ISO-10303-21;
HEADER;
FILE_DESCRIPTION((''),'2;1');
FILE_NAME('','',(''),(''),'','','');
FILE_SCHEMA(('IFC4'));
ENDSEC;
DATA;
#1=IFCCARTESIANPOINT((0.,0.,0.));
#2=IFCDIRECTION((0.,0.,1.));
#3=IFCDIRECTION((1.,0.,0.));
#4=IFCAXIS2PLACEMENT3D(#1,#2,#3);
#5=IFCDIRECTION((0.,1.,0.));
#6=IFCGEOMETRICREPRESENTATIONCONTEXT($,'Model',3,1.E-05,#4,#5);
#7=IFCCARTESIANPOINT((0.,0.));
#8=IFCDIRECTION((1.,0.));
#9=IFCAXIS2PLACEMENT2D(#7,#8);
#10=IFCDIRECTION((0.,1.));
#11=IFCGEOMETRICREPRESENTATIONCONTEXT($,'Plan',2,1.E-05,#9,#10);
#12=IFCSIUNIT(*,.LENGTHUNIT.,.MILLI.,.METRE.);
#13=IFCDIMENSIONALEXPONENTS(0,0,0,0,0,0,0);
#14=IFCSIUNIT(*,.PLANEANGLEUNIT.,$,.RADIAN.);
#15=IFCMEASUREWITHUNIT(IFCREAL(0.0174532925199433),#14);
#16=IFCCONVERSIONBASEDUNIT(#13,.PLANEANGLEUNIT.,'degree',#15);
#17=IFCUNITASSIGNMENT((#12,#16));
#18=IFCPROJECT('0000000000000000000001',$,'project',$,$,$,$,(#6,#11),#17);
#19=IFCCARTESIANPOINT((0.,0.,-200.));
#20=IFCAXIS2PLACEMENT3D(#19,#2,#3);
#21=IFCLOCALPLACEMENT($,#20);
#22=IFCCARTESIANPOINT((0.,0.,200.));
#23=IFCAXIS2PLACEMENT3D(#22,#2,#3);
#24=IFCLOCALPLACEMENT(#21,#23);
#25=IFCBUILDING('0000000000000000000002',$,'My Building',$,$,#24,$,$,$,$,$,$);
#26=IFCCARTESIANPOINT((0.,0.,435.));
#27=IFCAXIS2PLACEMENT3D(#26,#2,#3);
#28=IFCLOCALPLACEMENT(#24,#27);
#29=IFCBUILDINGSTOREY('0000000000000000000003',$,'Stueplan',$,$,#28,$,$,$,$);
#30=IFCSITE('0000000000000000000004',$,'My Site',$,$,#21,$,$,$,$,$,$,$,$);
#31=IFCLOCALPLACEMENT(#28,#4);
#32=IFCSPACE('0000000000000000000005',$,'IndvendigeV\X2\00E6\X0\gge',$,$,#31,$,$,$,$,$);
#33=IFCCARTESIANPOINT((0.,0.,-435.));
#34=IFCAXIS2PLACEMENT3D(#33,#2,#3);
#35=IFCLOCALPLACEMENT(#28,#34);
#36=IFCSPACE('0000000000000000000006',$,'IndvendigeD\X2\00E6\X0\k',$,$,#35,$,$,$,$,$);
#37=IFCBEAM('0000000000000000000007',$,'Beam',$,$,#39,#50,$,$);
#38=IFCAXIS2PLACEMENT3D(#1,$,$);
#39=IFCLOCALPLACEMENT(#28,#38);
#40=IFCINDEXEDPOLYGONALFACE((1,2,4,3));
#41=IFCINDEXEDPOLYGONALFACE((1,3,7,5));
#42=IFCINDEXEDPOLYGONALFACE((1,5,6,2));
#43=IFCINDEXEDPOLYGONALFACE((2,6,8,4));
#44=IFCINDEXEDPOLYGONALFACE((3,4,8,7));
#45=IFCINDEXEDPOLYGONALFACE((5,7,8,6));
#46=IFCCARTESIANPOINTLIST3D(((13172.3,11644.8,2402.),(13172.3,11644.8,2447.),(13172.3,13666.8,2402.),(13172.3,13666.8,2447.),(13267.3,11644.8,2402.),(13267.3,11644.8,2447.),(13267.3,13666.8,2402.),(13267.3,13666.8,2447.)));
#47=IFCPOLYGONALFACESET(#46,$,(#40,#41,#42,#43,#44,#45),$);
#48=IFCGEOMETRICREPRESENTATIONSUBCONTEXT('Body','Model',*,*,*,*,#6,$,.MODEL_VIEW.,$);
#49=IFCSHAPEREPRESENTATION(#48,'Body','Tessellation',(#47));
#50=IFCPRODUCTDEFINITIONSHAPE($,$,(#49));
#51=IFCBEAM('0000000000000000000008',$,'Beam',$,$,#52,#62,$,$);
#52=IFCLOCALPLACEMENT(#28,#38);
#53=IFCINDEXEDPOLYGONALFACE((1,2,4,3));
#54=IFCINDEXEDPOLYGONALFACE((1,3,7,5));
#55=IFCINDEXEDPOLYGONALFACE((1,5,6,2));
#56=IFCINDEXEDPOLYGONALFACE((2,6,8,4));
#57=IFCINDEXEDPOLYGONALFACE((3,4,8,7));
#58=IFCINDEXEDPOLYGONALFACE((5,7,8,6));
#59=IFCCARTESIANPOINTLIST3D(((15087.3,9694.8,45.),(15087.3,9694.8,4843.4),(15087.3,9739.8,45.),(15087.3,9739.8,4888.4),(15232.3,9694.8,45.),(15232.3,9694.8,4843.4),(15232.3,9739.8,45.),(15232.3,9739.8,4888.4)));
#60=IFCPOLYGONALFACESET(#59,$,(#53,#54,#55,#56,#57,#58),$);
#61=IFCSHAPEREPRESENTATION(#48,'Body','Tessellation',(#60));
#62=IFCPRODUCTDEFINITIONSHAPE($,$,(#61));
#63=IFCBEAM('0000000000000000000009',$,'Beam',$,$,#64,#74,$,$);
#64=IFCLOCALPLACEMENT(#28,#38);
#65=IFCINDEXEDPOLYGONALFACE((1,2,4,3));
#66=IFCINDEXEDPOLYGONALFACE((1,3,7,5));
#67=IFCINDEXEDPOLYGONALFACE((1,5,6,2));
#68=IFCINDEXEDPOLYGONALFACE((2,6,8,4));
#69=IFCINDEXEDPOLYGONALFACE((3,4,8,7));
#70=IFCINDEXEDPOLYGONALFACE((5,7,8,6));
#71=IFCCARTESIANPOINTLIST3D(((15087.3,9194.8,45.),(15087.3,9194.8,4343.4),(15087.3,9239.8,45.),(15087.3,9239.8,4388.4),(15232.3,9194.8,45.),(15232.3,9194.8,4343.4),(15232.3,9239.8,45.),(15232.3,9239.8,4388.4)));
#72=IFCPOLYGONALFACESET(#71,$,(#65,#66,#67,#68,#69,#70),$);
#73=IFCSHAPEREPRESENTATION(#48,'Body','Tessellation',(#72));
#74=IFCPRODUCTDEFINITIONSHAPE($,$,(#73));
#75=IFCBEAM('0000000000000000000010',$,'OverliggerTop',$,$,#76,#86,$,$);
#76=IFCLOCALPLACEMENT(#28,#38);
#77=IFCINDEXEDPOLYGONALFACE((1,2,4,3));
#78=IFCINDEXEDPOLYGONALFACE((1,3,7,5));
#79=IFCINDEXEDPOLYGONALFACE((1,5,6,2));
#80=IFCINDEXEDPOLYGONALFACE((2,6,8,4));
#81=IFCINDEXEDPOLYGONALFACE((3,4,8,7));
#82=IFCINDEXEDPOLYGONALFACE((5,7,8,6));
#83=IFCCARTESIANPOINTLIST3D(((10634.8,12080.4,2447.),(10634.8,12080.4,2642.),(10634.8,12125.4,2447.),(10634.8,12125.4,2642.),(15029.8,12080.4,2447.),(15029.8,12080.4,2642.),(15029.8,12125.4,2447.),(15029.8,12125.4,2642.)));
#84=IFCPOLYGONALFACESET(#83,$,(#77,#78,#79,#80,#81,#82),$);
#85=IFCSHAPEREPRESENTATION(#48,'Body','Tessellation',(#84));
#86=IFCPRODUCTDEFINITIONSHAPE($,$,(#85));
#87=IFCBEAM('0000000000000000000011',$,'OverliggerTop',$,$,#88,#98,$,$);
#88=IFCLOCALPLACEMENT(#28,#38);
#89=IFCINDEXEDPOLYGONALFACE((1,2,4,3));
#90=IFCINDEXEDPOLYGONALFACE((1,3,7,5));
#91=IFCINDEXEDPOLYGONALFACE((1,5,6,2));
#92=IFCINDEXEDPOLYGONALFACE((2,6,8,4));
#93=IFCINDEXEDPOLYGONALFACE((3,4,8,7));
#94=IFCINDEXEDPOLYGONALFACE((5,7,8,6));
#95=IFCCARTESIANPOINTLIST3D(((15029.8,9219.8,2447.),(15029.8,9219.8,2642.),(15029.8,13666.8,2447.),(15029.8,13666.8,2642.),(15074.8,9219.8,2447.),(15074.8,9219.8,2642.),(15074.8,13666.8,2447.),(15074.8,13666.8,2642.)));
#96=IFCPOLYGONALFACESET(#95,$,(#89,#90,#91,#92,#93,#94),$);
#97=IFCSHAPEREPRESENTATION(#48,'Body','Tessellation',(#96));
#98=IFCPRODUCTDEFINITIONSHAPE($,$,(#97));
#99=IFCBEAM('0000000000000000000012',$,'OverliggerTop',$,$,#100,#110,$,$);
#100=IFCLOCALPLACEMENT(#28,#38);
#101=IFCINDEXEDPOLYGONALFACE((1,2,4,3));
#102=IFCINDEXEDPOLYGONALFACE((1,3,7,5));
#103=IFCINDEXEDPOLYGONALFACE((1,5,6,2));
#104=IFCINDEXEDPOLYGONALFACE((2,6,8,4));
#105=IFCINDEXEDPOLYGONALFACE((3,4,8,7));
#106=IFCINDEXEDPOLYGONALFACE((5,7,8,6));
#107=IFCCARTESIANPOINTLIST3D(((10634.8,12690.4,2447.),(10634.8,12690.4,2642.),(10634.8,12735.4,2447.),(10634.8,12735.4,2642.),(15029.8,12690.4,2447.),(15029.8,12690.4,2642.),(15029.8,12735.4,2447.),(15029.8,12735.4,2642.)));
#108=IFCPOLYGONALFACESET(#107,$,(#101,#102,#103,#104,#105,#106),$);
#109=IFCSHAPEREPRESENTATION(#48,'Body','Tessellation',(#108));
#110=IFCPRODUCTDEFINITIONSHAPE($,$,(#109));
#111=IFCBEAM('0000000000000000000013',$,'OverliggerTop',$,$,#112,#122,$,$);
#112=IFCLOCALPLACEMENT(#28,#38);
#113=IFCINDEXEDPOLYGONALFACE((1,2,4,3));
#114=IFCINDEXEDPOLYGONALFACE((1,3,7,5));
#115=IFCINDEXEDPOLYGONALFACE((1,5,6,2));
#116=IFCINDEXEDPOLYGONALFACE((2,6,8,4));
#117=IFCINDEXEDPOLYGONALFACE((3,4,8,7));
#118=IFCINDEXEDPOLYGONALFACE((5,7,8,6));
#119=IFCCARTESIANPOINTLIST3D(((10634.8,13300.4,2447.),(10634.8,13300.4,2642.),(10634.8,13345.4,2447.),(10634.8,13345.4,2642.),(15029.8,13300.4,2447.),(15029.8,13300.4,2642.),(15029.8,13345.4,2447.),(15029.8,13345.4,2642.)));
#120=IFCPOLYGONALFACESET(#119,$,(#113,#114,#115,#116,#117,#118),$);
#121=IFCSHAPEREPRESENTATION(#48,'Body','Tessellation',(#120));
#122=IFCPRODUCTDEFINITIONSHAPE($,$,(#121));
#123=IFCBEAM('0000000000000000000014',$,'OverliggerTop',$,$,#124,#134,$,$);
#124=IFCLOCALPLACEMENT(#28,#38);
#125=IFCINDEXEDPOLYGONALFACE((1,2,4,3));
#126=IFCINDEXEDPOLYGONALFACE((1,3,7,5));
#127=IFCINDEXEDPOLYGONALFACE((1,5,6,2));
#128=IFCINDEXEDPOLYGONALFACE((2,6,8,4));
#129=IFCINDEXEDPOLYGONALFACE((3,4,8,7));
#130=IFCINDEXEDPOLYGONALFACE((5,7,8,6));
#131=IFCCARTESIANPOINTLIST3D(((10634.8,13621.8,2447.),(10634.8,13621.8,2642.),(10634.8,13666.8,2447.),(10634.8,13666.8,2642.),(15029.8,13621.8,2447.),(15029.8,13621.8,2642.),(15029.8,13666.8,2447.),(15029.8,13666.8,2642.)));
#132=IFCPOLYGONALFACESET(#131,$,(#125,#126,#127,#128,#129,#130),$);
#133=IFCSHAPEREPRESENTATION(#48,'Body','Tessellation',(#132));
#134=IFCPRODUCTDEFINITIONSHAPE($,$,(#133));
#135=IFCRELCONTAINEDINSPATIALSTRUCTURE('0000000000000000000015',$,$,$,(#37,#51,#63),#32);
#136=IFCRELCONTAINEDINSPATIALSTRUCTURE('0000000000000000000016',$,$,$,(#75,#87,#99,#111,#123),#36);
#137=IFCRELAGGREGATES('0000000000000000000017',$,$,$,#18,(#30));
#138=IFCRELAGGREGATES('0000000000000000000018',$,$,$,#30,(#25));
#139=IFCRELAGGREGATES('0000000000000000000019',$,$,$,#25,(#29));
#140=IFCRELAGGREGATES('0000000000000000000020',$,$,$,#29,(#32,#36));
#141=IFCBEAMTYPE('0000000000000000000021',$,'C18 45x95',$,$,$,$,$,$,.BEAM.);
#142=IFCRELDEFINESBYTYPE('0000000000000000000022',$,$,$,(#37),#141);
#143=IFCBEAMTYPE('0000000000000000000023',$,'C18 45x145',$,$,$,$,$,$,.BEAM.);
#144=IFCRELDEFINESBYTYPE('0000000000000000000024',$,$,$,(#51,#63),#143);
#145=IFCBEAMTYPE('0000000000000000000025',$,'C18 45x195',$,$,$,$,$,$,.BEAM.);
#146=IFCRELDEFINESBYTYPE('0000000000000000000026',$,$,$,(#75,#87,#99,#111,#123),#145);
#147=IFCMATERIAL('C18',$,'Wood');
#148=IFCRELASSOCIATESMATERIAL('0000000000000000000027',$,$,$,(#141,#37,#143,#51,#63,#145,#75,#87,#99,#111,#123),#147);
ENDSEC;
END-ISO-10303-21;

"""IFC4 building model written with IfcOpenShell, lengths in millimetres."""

from ifc_helpers import new_model, entity, si_unit, converted_unit, direction, frame, origin_with_axes, origin_2d_with_axis, place, context, subcontext, project, spatial, rectangle, extrude, clip, halfspace, material, material_profile, profile_set, profile_usage, type_object, element, save


model = new_model("IFC4")

# Units and contexts
model_context = context("Model", 3, precision=1e-05, world=origin_with_axes(), true_north=direction((0.0, 1.0, 0.0)))
plan_context = context("Plan", 2, precision=1e-05, world=origin_2d_with_axis(), true_north=direction((0.0, 1.0)))
body_context_1 = subcontext(model_context, "Body", "Model", "MODEL_VIEW")
ifc_project = project(units=[si_unit("LENGTHUNIT", "METRE", prefix="MILLI"), converted_unit("PLANEANGLEUNIT", "degree", entity("IfcReal", 0.0174532925199433), si_unit("PLANEANGLEUNIT", "RADIAN"), dimensions=[0, 0, 0, 0, 0, 0, 0])], contexts=[model_context, plan_context])

# Site, building, storey
site_placement = place(None, frame((0.0, 0.0, -200.0), z_axis=(0.0, 0.0, 1.0), x_axis=(1.0, 0.0, 0.0)))
site = spatial("IfcSite", under=ifc_project, at=site_placement, Name="My Site")
building_placement = place(site_placement, frame((0.0, 0.0, 200.0), z_axis=(0.0, 0.0, 1.0), x_axis=(1.0, 0.0, 0.0)))
building = spatial("IfcBuilding", under=site, at=building_placement, Name="My Building")
storey_placement = place(building_placement, frame((0.0, 0.0, 435.0), z_axis=(0.0, 0.0, 1.0), x_axis=(1.0, 0.0, 0.0)))
storey = spatial("IfcBuildingStorey", under=building, at=storey_placement, Name="Stueplan")

# Shared definitions
ifc_material = material(Name="C18", Category="Wood")

# Shared definitions
space_1_placement = place(storey_placement, frame((0.0, 0.0, 0.0), z_axis=(0.0, 0.0, 1.0), x_axis=(1.0, 0.0, 0.0)))
space_1 = spatial("IfcSpace", under=storey, at=space_1_placement, Name="IndvendigeVægge")

# Beams
ifc_material_profile_1 = material_profile(ifc_material, rectangle(XDim=45.0, YDim=95.0))
ifc_profile_set_1 = profile_set([ifc_material_profile_1], Name="woodStructural")
beam_type_1 = type_object("IfcBeamType", Name="C18 45x95", PredefinedType="BEAM", material=ifc_profile_set_1)
ifc_profile_usage_1 = profile_usage(ifc_profile_set_1, cardinal=5)
beam_1_placement = place(space_1_placement, frame((13219.8, 11644.8, 2424.5), z_axis=(0.0, 1.0, 0.0), x_axis=(0.0, 0.0, 1.0)))
element("IfcBeam", 1, at=beam_1_placement, inside=space_1, type_object=beam_type_1, material=ifc_profile_usage_1, Name="Beam", context=body_context_1, shape_type="SweptSolid", body=[
    extrude(rectangle(XDim=45.0, YDim=95.0), origin_with_axes(), (0.0, 0.0, 1.0), 2022.0),
])
ifc_material_profile_2 = material_profile(ifc_material, rectangle(XDim=45.0, YDim=145.0))
ifc_profile_set_2 = profile_set([ifc_material_profile_2], Name="woodStructural")
ifc_profile_usage_2 = profile_usage(ifc_profile_set_2)
beam_type_2 = type_object("IfcBeamType", Name="C18 45x145", PredefinedType="BEAM", material=ifc_profile_set_2)
beam_2_placement = place(space_1_placement, frame((15159.8, 9717.3, 45.0), z_axis=(0.0, 0.0, 1.0), x_axis=(0.0, -1.0, 0.0)))
element("IfcBeam", 2, at=beam_2_placement, inside=space_1, type_object=beam_type_2, material=ifc_profile_usage_2, Name="Beam", context=body_context_1, shape_type="Clipping", body=[
    clip(extrude(rectangle(XDim=45.0, YDim=145.0), origin_with_axes(), (0.0, 0.0, 1.0), 4965.9), halfspace(frame((609.1, 0.0, 4211.8), z_axis=(0.707107, 0.0, 0.707107), x_axis=(0.0, -1.0, 0.0)), False)),
])
ifc_profile_usage_3 = profile_usage(ifc_profile_set_2)
beam_3_placement = place(space_1_placement, frame((15159.8, 9217.3, 45.0), z_axis=(0.0, 0.0, 1.0), x_axis=(0.0, -1.0, 0.0)))
element("IfcBeam", 3, at=beam_3_placement, inside=space_1, type_object=beam_type_2, material=ifc_profile_usage_3, Name="Beam", context=body_context_1, shape_type="Clipping", body=[
    clip(extrude(rectangle(XDim=45.0, YDim=145.0), origin_with_axes(), (0.0, 0.0, 1.0), 4465.9), halfspace(frame((109.1, 0.0, 4211.8), z_axis=(0.707107, 0.0, 0.707107), x_axis=(0.0, -1.0, 0.0)), False)),
])

# Shared definitions
space_2_placement = place(storey_placement, frame((0.0, 0.0, -435.0), z_axis=(0.0, 0.0, 1.0), x_axis=(1.0, 0.0, 0.0)))
space_2 = spatial("IfcSpace", under=storey, at=space_2_placement, Name="IndvendigeDæk")

# Beams
ifc_material_profile_3 = material_profile(ifc_material, rectangle(XDim=45.0, YDim=195.0))
ifc_profile_set_3 = profile_set([ifc_material_profile_3], Name="woodStructural")
ifc_profile_usage_4 = profile_usage(ifc_profile_set_3)
beam_type_3 = type_object("IfcBeamType", Name="C18 45x195", PredefinedType="BEAM", material=ifc_profile_set_3)
beam_4_placement = place(space_2_placement, frame((15029.8, 12102.9, 2979.5), z_axis=(-1.0, -0.000001, 0.0), x_axis=(-0.000001, 1.0, 0.0)))
element("IfcBeam", 4, at=beam_4_placement, inside=space_2, type_object=beam_type_3, material=ifc_profile_usage_4, Name="OverliggerTop", context=body_context_1, shape_type="SweptSolid", body=[
    extrude(rectangle(XDim=45.0, YDim=195.0), origin_with_axes(), (0.0, 0.0, 1.0), 4395.0),
])
ifc_profile_usage_5 = profile_usage(ifc_profile_set_3)
beam_5_placement = place(space_2_placement, frame((15052.3, 13666.8, 2979.5), z_axis=(0.000001, -1.0, 0.0), x_axis=(-1.0, -0.000001, 0.0)))
element("IfcBeam", 5, at=beam_5_placement, inside=space_2, type_object=beam_type_3, material=ifc_profile_usage_5, Name="OverliggerTop", context=body_context_1, shape_type="SweptSolid", body=[
    extrude(rectangle(XDim=45.0, YDim=195.0), origin_with_axes(), (0.0, 0.0, 1.0), 4447.0),
])
ifc_profile_usage_6 = profile_usage(ifc_profile_set_3)
beam_6_placement = place(space_2_placement, frame((15029.8, 12712.9, 2979.5), z_axis=(-1.0, -0.000001, 0.0), x_axis=(-0.000001, 1.0, 0.0)))
element("IfcBeam", 6, at=beam_6_placement, inside=space_2, type_object=beam_type_3, material=ifc_profile_usage_6, Name="OverliggerTop", context=body_context_1, shape_type="SweptSolid", body=[
    extrude(rectangle(XDim=45.0, YDim=195.0), origin_with_axes(), (0.0, 0.0, 1.0), 4395.0),
])
ifc_profile_usage_7 = profile_usage(ifc_profile_set_3)
beam_7_placement = place(space_2_placement, frame((15029.8, 13322.9, 2979.5), z_axis=(-1.0, -0.000001, 0.0), x_axis=(-0.000001, 1.0, 0.0)))
element("IfcBeam", 7, at=beam_7_placement, inside=space_2, type_object=beam_type_3, material=ifc_profile_usage_7, Name="OverliggerTop", context=body_context_1, shape_type="SweptSolid", body=[
    extrude(rectangle(XDim=45.0, YDim=195.0), origin_with_axes(), (0.0, 0.0, 1.0), 4395.0),
])
ifc_profile_usage_8 = profile_usage(ifc_profile_set_3)
beam_8_placement = place(space_2_placement, frame((15029.8, 13644.3, 2979.5), z_axis=(-1.0, -0.000001, 0.0), x_axis=(-0.000001, 1.0, 0.0)))
element("IfcBeam", 8, at=beam_8_placement, inside=space_2, type_object=beam_type_3, material=ifc_profile_usage_8, Name="OverliggerTop", context=body_context_1, shape_type="SweptSolid", body=[
    extrude(rectangle(XDim=45.0, YDim=195.0), origin_with_axes(), (0.0, 0.0, 1.0), 4395.0),
])

save(model, "model.ifc")
